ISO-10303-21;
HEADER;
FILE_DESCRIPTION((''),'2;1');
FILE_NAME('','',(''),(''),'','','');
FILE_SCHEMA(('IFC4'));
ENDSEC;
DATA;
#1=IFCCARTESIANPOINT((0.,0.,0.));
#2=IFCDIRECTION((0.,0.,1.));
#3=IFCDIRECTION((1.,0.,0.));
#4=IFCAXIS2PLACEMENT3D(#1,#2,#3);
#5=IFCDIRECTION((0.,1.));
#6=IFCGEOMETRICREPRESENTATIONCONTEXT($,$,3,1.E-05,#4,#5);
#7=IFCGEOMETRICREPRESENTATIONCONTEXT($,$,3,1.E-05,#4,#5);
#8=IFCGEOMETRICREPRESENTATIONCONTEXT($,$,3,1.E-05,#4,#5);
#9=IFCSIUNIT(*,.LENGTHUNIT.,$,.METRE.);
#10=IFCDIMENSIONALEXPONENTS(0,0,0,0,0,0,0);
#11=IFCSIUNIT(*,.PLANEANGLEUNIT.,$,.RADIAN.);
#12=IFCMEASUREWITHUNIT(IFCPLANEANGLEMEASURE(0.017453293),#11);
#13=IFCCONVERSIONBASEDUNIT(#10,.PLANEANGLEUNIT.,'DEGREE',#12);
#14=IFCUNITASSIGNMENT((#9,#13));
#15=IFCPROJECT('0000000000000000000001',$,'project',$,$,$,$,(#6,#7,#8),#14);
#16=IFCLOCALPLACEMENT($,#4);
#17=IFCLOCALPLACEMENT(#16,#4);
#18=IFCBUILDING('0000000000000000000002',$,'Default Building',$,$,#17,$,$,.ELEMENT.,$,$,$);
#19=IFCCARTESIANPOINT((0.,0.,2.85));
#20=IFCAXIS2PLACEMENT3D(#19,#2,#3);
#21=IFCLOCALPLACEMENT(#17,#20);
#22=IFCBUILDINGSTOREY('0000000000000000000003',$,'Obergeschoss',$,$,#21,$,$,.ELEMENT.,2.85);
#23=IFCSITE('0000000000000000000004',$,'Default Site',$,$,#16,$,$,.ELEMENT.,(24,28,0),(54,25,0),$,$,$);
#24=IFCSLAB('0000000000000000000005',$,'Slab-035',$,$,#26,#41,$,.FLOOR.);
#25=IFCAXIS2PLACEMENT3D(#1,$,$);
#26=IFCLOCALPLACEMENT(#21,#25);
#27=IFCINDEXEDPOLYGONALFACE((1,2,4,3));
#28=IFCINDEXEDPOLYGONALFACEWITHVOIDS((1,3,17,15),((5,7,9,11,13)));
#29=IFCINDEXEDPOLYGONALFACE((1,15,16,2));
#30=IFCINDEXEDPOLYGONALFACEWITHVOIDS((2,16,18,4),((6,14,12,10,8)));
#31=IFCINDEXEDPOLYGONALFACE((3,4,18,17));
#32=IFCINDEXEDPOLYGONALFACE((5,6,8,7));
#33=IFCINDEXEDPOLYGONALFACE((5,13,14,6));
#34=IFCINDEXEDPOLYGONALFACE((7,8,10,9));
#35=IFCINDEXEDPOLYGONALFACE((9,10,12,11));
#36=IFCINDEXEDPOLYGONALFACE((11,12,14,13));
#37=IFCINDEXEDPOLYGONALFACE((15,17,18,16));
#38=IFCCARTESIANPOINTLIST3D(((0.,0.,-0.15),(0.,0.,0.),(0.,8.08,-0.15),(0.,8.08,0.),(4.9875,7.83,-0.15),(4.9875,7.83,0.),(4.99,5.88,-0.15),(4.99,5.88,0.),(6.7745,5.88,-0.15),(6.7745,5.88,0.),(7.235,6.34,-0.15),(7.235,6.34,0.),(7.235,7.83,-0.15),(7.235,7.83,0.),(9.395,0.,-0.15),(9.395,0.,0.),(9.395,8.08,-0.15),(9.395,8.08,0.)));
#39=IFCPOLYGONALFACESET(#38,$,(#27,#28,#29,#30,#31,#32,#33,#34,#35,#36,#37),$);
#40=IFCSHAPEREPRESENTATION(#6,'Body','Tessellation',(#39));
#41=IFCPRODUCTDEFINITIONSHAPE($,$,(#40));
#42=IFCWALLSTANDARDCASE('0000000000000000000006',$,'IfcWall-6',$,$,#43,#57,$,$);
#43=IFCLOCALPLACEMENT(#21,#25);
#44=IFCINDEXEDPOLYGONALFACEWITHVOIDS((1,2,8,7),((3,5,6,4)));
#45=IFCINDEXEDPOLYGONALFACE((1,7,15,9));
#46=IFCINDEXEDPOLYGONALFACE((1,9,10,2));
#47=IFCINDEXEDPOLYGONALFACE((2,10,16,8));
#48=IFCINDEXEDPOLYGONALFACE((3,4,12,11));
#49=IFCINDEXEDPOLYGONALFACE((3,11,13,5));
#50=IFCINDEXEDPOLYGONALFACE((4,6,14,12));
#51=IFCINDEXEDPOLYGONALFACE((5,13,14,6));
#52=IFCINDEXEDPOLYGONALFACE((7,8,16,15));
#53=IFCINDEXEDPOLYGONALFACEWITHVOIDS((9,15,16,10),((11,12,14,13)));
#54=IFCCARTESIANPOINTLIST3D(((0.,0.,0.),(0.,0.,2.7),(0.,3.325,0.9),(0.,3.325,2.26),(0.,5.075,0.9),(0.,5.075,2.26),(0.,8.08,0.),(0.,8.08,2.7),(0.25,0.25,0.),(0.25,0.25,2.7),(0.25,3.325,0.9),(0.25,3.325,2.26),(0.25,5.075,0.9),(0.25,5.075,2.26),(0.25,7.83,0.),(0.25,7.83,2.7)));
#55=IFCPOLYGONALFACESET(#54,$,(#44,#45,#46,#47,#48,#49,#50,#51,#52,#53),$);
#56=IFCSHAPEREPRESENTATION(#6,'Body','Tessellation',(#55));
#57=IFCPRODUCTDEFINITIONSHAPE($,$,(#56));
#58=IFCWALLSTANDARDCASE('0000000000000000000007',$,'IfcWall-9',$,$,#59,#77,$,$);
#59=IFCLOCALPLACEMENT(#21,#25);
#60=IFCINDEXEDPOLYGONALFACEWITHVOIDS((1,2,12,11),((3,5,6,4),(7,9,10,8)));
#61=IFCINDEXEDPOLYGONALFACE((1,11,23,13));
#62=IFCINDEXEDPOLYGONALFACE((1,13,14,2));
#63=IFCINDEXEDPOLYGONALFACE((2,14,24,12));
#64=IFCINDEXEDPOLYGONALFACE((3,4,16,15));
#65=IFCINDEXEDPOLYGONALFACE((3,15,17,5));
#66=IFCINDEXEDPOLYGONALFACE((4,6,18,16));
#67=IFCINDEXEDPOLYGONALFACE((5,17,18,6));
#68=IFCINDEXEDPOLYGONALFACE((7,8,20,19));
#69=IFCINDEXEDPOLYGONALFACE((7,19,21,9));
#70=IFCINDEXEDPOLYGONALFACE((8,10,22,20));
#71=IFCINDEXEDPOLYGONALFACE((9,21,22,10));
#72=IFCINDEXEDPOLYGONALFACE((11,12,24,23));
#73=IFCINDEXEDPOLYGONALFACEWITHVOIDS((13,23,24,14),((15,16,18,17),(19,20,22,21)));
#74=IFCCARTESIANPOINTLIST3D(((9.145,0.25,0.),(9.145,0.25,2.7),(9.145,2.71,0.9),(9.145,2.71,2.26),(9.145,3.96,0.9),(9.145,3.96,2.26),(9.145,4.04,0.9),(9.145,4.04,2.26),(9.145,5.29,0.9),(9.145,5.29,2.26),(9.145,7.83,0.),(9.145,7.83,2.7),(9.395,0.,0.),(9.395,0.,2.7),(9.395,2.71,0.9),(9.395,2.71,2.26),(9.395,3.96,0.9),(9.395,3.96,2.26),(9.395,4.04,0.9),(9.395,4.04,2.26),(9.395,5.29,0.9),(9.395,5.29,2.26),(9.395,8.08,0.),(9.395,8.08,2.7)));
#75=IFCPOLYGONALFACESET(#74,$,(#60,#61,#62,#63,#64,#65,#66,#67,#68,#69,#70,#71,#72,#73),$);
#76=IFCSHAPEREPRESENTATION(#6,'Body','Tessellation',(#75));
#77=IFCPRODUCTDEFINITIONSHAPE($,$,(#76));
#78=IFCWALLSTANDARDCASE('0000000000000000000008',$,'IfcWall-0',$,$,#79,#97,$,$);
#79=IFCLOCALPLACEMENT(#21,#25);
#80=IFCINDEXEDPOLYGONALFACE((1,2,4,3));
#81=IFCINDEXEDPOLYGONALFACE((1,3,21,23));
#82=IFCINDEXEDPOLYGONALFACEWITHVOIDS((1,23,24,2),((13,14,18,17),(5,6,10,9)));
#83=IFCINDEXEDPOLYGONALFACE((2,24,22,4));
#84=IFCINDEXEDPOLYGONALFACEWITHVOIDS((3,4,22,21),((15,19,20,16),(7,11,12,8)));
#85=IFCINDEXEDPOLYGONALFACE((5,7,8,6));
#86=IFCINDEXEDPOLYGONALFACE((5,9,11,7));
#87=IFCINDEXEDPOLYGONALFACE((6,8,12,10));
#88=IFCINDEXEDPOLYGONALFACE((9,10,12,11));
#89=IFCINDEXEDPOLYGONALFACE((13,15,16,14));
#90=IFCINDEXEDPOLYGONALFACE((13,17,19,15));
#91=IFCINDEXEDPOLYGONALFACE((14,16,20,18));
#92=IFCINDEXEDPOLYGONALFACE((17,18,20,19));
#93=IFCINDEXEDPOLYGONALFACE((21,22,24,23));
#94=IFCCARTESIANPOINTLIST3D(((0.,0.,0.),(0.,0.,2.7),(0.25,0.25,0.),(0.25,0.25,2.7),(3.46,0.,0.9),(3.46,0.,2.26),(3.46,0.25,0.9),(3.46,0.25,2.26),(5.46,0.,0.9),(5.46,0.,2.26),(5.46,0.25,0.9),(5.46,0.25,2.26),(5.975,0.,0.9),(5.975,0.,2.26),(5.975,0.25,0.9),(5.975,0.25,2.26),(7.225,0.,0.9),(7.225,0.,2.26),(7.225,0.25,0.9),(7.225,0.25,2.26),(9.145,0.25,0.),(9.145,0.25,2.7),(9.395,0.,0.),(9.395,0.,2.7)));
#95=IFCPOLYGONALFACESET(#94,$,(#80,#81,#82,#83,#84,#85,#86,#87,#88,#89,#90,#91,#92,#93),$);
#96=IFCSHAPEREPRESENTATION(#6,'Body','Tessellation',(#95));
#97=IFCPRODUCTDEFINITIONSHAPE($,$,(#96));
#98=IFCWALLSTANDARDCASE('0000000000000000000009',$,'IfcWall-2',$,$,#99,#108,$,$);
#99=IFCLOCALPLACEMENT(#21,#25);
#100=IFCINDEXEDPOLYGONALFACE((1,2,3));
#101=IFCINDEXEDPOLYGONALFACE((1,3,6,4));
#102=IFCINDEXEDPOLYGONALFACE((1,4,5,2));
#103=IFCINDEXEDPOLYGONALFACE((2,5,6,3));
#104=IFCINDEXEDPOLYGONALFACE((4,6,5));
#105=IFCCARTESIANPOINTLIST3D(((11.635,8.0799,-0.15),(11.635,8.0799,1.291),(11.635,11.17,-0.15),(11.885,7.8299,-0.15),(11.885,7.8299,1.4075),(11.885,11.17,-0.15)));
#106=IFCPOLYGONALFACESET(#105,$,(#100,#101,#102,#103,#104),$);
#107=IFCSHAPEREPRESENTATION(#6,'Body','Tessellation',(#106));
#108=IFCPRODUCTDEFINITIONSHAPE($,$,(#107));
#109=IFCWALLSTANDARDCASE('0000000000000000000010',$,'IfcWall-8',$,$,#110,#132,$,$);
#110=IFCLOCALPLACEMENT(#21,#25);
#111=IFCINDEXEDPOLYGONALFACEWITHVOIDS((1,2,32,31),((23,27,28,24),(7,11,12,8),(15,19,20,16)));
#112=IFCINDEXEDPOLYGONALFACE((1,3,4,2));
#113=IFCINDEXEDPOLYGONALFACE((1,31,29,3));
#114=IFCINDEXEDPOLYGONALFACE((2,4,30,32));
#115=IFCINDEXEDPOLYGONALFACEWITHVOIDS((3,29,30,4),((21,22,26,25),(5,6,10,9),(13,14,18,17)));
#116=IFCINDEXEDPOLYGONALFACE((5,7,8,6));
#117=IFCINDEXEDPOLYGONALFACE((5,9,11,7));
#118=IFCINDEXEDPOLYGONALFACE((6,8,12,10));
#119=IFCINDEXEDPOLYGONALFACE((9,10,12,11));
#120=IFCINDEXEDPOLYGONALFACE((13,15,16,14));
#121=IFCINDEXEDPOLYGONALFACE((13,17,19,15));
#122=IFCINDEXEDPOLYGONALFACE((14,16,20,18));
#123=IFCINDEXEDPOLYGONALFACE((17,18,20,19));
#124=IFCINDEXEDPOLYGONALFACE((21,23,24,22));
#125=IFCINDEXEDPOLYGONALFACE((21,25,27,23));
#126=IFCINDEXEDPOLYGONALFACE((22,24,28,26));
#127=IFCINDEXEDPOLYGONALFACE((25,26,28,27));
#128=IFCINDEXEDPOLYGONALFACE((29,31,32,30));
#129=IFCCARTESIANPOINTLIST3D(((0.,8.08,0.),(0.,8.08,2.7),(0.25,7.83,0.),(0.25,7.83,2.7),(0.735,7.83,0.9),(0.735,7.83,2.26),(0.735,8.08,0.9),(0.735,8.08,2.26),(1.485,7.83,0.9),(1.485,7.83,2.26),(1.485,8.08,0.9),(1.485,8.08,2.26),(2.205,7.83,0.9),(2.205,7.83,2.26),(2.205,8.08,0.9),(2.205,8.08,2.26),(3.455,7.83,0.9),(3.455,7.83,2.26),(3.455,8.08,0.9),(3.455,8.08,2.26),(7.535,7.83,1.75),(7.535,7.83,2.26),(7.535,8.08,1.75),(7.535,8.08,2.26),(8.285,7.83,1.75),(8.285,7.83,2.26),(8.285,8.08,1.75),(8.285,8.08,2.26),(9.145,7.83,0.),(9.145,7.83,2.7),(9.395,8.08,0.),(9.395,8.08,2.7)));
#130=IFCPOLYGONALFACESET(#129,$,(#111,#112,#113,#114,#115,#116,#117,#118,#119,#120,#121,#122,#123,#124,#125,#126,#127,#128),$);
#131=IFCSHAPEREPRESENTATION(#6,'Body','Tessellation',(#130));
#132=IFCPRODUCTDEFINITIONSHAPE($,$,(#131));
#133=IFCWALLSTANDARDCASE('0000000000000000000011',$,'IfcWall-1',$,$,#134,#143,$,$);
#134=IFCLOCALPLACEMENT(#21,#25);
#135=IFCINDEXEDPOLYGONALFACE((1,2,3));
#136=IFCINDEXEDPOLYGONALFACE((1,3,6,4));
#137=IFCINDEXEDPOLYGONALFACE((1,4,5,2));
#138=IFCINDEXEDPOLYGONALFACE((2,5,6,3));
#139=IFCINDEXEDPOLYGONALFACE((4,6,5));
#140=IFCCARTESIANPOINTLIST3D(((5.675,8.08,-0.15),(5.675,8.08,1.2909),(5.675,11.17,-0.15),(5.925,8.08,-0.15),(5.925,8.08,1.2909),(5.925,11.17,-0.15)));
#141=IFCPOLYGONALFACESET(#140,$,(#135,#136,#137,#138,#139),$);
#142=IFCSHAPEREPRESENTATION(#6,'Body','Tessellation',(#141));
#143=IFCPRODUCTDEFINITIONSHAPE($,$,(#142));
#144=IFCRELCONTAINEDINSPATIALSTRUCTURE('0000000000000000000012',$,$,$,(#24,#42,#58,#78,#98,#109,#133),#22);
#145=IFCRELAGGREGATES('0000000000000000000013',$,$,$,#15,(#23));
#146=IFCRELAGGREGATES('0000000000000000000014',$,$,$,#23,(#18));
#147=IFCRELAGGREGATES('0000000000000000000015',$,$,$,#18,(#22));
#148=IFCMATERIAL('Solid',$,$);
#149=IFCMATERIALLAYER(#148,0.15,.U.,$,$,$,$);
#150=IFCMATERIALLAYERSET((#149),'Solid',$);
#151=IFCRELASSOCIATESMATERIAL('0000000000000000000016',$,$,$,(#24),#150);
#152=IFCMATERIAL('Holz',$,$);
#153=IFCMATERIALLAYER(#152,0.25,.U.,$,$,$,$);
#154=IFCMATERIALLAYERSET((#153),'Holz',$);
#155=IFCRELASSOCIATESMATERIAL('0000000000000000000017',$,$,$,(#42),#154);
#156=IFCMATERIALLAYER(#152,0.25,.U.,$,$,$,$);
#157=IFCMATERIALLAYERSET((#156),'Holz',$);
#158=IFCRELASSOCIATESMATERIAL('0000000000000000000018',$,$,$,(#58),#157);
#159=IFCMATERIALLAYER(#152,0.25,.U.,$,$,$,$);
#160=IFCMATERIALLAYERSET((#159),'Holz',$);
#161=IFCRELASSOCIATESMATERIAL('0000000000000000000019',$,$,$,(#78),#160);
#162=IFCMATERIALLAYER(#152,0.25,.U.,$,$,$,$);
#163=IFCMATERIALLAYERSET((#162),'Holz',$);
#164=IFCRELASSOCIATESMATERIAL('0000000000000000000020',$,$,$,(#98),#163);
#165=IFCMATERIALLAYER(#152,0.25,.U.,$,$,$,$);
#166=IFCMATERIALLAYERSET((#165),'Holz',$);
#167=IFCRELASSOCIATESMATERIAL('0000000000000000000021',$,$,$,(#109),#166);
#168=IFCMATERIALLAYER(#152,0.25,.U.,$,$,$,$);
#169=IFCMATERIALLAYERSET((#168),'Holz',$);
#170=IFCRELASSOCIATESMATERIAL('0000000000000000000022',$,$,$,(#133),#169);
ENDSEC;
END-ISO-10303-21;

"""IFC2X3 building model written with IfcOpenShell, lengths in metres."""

from ifc_helpers import new_model, entity, si_unit, converted_unit, direction, frame, frame_2d, origin_with_axes, place, context, project, spatial, polyline, rectangle, outline, extrude, clip, halfspace, bounded_halfspace, material, layer, layer_set, layer_usage, element, save


model = new_model("IFC2X3")

# Units and contexts
context_of_model_1 = context(None, 3, precision=1e-05, world=origin_with_axes(), true_north=direction((0.0, 1.0)))
context_of_model_2 = context(None, 3, precision=1e-05, world=origin_with_axes(), true_north=direction((0.0, 1.0)))
context_of_model_3 = context(None, 3, precision=1e-05, world=origin_with_axes(), true_north=direction((0.0, 1.0)))
ifc_project = project(units=[si_unit("LENGTHUNIT", "METRE"), converted_unit("PLANEANGLEUNIT", "DEGREE", entity("IfcPlaneAngleMeasure", 0.017453293), si_unit("PLANEANGLEUNIT", "RADIAN"), dimensions=[0, 0, 0, 0, 0, 0, 0])], contexts=[context_of_model_1, context_of_model_2, context_of_model_3])

# Site, building, storey
site_placement = place(None, origin_with_axes())
site = spatial("IfcSite", under=ifc_project, at=site_placement, Name="Default Site", CompositionType="ELEMENT", RefLatitude=(24, 28, 0), RefLongitude=(54, 25, 0))
building_placement = place(site_placement, origin_with_axes())
building = spatial("IfcBuilding", under=site, at=building_placement, Name="Default Building", CompositionType="ELEMENT")
storey_placement = place(building_placement, frame((0.0, 0.0, 2.85), z_axis=(0.0, 0.0, 1.0), x_axis=(1.0, 0.0, 0.0)))
storey = spatial("IfcBuildingStorey", under=building, at=storey_placement, Name="Obergeschoss", CompositionType="ELEMENT", Elevation=2.85)

# Slab, opening
ifc_material_1 = material(Name="Solid")
ifc_layer_1 = layer(ifc_material_1, 0.15, ventilated="UNKNOWN")
ifc_layer_set_1 = layer_set([ifc_layer_1], Name="Solid")
ifc_layer_usage_1 = layer_usage(ifc_layer_set_1, "AXIS3", "NEGATIVE", 0.15)
slab_1_placement = place(storey_placement, frame((0.0, 8.08, -0.15), z_axis=(0.0, 0.0, 1.0), x_axis=(1.0, 0.0, 0.0)))
slab_1 = element("IfcSlab", 1, at=slab_1_placement, inside=storey, material=ifc_layer_usage_1, Name="Slab-035", PredefinedType="FLOOR", context=context_of_model_1, shape_type="SweptSolid", body=[
    extrude(outline(polyline([(0.0, 0.0), (9.395, 0.0), (9.395, -8.08), (0.0, -8.08), (0.0, 0.0)])), origin_with_axes(), (0.0, 0.0, 1.0), 0.15),
])
opening_1_placement = place(slab_1_placement, origin_with_axes())
element("IfcOpeningElement", 2, at=opening_1_placement, cuts=slab_1, context=context_of_model_1, shape_type="SweptSolid", body=[
    extrude(outline(polyline([(4.9875, -0.25), (7.235, -0.25), (7.235, -1.74), (6.7745, -2.2), (4.99, -2.2), (4.9875, -0.25)])), origin_with_axes(), (0.0, 0.0, 1.0), 0.15),
])

# Wall, opening
ifc_material_2 = material(Name="Holz")
ifc_layer_2 = layer(ifc_material_2, 0.25, ventilated="UNKNOWN")
ifc_layer_set_2 = layer_set([ifc_layer_2], Name="Holz")
ifc_layer_usage_2 = layer_usage(ifc_layer_set_2, "AXIS2", "NEGATIVE", 0.0)
wall_1_placement = place(storey_placement, frame((0.0, 0.0, 0.0), z_axis=(0.0, 0.0, 1.0), x_axis=(0.0, 1.0, 0.0)))
wall_1 = element("IfcWallStandardCase", 3, at=wall_1_placement, inside=storey, material=ifc_layer_usage_2, Name="IfcWall-6", context=context_of_model_1, shape_type="SweptSolid", body=[
    extrude(outline(polyline([(0.25, -0.25), (7.83, -0.25), (8.08, 0.0), (0.0, 0.0), (0.25, -0.25)])), origin_with_axes(), (0.0, 0.0, 1.0), 2.7),
])
opening_2_placement = place(wall_1_placement, frame((4.2, -0.25, 0.9), z_axis=(0.0, 0.0, 1.0), x_axis=(1.0, 0.0, 0.0)))
element("IfcOpeningElement", 4, at=opening_2_placement, cuts=wall_1, context=context_of_model_1, shape_type="SweptSolid", body=[
    extrude(rectangle(XDim=1.36, YDim=1.75, at=frame_2d((0.0, 0.68), x_axis=(0.0, -1.0))), frame((0.0, 0.0, 0.0), z_axis=(0.0, 1.0, 0.0), x_axis=(-1.0, 0.0, 0.0)), (0.0, 0.0, 1.0), 0.25),
])

# Walls, openings
ifc_layer_3 = layer(ifc_material_2, 0.25, ventilated="UNKNOWN")
ifc_layer_set_3 = layer_set([ifc_layer_3], Name="Holz")
ifc_layer_usage_3 = layer_usage(ifc_layer_set_3, "AXIS2", "NEGATIVE", 0.0)
wall_2_placement = place(storey_placement, frame((9.395, 8.08, 0.0), z_axis=(0.0, 0.0, 1.0), x_axis=(0.0, -1.0, 0.0)))
wall_2 = element("IfcWallStandardCase", 5, at=wall_2_placement, inside=storey, material=ifc_layer_usage_3, Name="IfcWall-9", context=context_of_model_1, shape_type="SweptSolid", body=[
    extrude(outline(polyline([(0.25, -0.25), (7.83, -0.25), (8.08, 0.0), (0.0, 0.0), (0.25, -0.25)])), origin_with_axes(), (0.0, 0.0, 1.0), 2.7),
])
opening_3_placement = place(wall_2_placement, frame((4.745, -0.25, 0.9), z_axis=(0.0, 0.0, 1.0), x_axis=(1.0, 0.0, 0.0)))
element("IfcOpeningElement", 6, at=opening_3_placement, cuts=wall_2, context=context_of_model_1, shape_type="SweptSolid", body=[
    extrude(rectangle(XDim=1.36, YDim=1.25, at=frame_2d((0.0, 0.68), x_axis=(0.0, -1.0))), frame((0.0, 0.0, 0.0), z_axis=(0.0, 1.0, 0.0), x_axis=(-1.0, 0.0, 0.0)), (0.0, 0.0, 1.0), 0.25),
])
opening_4_placement = place(wall_2_placement, frame((3.415, -0.25, 0.9), z_axis=(0.0, 0.0, 1.0), x_axis=(1.0, 0.0, 0.0)))
element("IfcOpeningElement", 7, at=opening_4_placement, cuts=wall_2, context=context_of_model_1, shape_type="SweptSolid", body=[
    extrude(rectangle(XDim=1.36, YDim=1.25, at=frame_2d((0.0, 0.68), x_axis=(0.0, -1.0))), frame((0.0, 0.0, 0.0), z_axis=(0.0, 1.0, 0.0), x_axis=(-1.0, 0.0, 0.0)), (0.0, 0.0, 1.0), 0.25),
])
ifc_layer_4 = layer(ifc_material_2, 0.25, ventilated="UNKNOWN")
ifc_layer_set_4 = layer_set([ifc_layer_4], Name="Holz")
ifc_layer_usage_4 = layer_usage(ifc_layer_set_4, "AXIS2", "NEGATIVE", 0.0)
wall_3_placement = place(storey_placement, frame((9.395, 0.0, 0.0), z_axis=(0.0, 0.0, 1.0), x_axis=(-1.0, 0.0, 0.0)))
wall_3 = element("IfcWallStandardCase", 8, at=wall_3_placement, inside=storey, material=ifc_layer_usage_4, Name="IfcWall-0", context=context_of_model_1, shape_type="SweptSolid", body=[
    extrude(outline(polyline([(0.25, -0.25), (9.145, -0.25), (9.395, 0.0), (0.0, 0.0), (0.25, -0.25)])), origin_with_axes(), (0.0, 0.0, 1.0), 2.7),
])
opening_5_placement = place(wall_3_placement, frame((4.935, -0.25, 0.9), z_axis=(0.0, 0.0, 1.0), x_axis=(1.0, 0.0, 0.0)))
element("IfcOpeningElement", 9, at=opening_5_placement, cuts=wall_3, context=context_of_model_1, shape_type="SweptSolid", body=[
    extrude(rectangle(XDim=1.36, YDim=2.0, at=frame_2d((0.0, 0.68), x_axis=(0.0, -1.0))), frame((0.0, 0.0, 0.0), z_axis=(0.0, 1.0, 0.0), x_axis=(-1.0, 0.0, 0.0)), (0.0, 0.0, 1.0), 0.25),
])
opening_6_placement = place(wall_3_placement, frame((2.795, -0.25, 0.9), z_axis=(0.0, 0.0, 1.0), x_axis=(1.0, 0.0, 0.0)))
element("IfcOpeningElement", 10, at=opening_6_placement, cuts=wall_3, context=context_of_model_1, shape_type="SweptSolid", body=[
    extrude(rectangle(XDim=1.36, YDim=1.25, at=frame_2d((0.0, 0.68), x_axis=(0.0, -1.0))), frame((0.0, 0.0, 0.0), z_axis=(0.0, 1.0, 0.0), x_axis=(-1.0, 0.0, 0.0)), (0.0, 0.0, 1.0), 0.25),
])

# Wall
ifc_layer_5 = layer(ifc_material_2, 0.25, ventilated="UNKNOWN")
ifc_layer_set_5 = layer_set([ifc_layer_5], Name="Holz")
ifc_layer_usage_5 = layer_usage(ifc_layer_set_5, "AXIS2", "NEGATIVE", 0.0)
wall_4_placement = place(storey_placement, frame((11.885, 11.17, -0.15), z_axis=(0.0, 0.0, 1.0), x_axis=(0.0, -1.0, 0.0)))
element("IfcWallStandardCase", 11, at=wall_4_placement, inside=storey, material=ifc_layer_usage_5, Name="IfcWall-2", context=context_of_model_1, shape_type="Clipping", body=[
    clip(extrude(outline(polyline([(0.0, -0.25), (3.0901, -0.25), (3.3401, 0.0), (0.0, 0.0), (0.0, -0.25)])), origin_with_axes(), (0.0, 0.0, 1.0), 2.7), halfspace(frame((0.0, 0.0, 0.0), z_axis=(-0.422618, 0.0, 0.906308), x_axis=(0.0, 1.0, 0.0)), False)),
])

# Wall, openings
ifc_layer_6 = layer(ifc_material_2, 0.25, ventilated="UNKNOWN")
ifc_layer_set_6 = layer_set([ifc_layer_6], Name="Holz")
ifc_layer_usage_6 = layer_usage(ifc_layer_set_6, "AXIS2", "NEGATIVE", 0.0)
wall_5_placement = place(storey_placement, frame((0.0, 8.08, 0.0), z_axis=(0.0, 0.0, 1.0), x_axis=(1.0, 0.0, 0.0)))
wall_5 = element("IfcWallStandardCase", 12, at=wall_5_placement, inside=storey, material=ifc_layer_usage_6, Name="IfcWall-8", context=context_of_model_1, shape_type="SweptSolid", body=[
    extrude(outline(polyline([(0.25, -0.25), (9.145, -0.25), (9.395, 0.0), (0.0, 0.0), (0.25, -0.25)])), origin_with_axes(), (0.0, 0.0, 1.0), 2.7),
])
opening_7_placement = place(wall_5_placement, frame((1.11, -0.25, 0.9), z_axis=(0.0, 0.0, 1.0), x_axis=(1.0, 0.0, 0.0)))
element("IfcOpeningElement", 13, at=opening_7_placement, cuts=wall_5, context=context_of_model_1, shape_type="SweptSolid", body=[
    extrude(rectangle(XDim=1.36, YDim=0.75, at=frame_2d((0.0, 0.68), x_axis=(0.0, -1.0))), frame((0.0, 0.0, 0.0), z_axis=(0.0, 1.0, 0.0), x_axis=(-1.0, 0.0, 0.0)), (0.0, 0.0, 1.0), 0.25),
])
opening_8_placement = place(wall_5_placement, frame((2.83, -0.25, 0.9), z_axis=(0.0, 0.0, 1.0), x_axis=(1.0, 0.0, 0.0)))
element("IfcOpeningElement", 14, at=opening_8_placement, cuts=wall_5, context=context_of_model_1, shape_type="SweptSolid", body=[
    extrude(rectangle(XDim=1.36, YDim=1.25, at=frame_2d((0.0, 0.68), x_axis=(0.0, -1.0))), frame((0.0, 0.0, 0.0), z_axis=(0.0, 1.0, 0.0), x_axis=(-1.0, 0.0, 0.0)), (0.0, 0.0, 1.0), 0.25),
])
opening_9_placement = place(wall_5_placement, frame((7.91, -0.25, 1.75), z_axis=(0.0, 0.0, 1.0), x_axis=(1.0, 0.0, 0.0)))
element("IfcOpeningElement", 15, at=opening_9_placement, cuts=wall_5, context=context_of_model_1, shape_type="SweptSolid", body=[
    extrude(rectangle(XDim=0.51, YDim=0.75, at=frame_2d((0.0, 0.255), x_axis=(0.0, -1.0))), frame((0.0, 0.0, 0.0), z_axis=(0.0, 1.0, 0.0), x_axis=(-1.0, 0.0, 0.0)), (0.0, 0.0, 1.0), 0.25),
])

# Wall
ifc_layer_7 = layer(ifc_material_2, 0.25, ventilated="UNKNOWN")
ifc_layer_set_7 = layer_set([ifc_layer_7], Name="Holz")
ifc_layer_usage_7 = layer_usage(ifc_layer_set_7, "AXIS2", "POSITIVE", 0.0)
wall_6_placement = place(storey_placement, frame((5.675, 11.17, -0.15), z_axis=(0.0, 0.0, 1.0), x_axis=(0.0, -1.0, 0.0)))
element("IfcWallStandardCase", 16, at=wall_6_placement, inside=storey, material=ifc_layer_usage_7, Name="IfcWall-1", context=context_of_model_1, shape_type="Clipping", body=[
    clip(extrude(outline(polyline([(0.0, 0.0), (3.09, 0.0), (3.09, 0.25), (0.0, 0.25), (0.0, 0.0)])), origin_with_axes(), (0.0, 0.0, 1.0), 2.7), bounded_halfspace(frame((0.0, 0.0, 0.0), z_axis=(-0.422618, 0.0, 0.906308), x_axis=(0.0, 1.0, 0.0)), False, origin_with_axes(), polyline([(3.09, -0.125), (3.09, 0.375), (-0.01, 0.375), (-0.01, -0.125), (3.09, -0.125)]))),
])

save(model, "model.ifc")
